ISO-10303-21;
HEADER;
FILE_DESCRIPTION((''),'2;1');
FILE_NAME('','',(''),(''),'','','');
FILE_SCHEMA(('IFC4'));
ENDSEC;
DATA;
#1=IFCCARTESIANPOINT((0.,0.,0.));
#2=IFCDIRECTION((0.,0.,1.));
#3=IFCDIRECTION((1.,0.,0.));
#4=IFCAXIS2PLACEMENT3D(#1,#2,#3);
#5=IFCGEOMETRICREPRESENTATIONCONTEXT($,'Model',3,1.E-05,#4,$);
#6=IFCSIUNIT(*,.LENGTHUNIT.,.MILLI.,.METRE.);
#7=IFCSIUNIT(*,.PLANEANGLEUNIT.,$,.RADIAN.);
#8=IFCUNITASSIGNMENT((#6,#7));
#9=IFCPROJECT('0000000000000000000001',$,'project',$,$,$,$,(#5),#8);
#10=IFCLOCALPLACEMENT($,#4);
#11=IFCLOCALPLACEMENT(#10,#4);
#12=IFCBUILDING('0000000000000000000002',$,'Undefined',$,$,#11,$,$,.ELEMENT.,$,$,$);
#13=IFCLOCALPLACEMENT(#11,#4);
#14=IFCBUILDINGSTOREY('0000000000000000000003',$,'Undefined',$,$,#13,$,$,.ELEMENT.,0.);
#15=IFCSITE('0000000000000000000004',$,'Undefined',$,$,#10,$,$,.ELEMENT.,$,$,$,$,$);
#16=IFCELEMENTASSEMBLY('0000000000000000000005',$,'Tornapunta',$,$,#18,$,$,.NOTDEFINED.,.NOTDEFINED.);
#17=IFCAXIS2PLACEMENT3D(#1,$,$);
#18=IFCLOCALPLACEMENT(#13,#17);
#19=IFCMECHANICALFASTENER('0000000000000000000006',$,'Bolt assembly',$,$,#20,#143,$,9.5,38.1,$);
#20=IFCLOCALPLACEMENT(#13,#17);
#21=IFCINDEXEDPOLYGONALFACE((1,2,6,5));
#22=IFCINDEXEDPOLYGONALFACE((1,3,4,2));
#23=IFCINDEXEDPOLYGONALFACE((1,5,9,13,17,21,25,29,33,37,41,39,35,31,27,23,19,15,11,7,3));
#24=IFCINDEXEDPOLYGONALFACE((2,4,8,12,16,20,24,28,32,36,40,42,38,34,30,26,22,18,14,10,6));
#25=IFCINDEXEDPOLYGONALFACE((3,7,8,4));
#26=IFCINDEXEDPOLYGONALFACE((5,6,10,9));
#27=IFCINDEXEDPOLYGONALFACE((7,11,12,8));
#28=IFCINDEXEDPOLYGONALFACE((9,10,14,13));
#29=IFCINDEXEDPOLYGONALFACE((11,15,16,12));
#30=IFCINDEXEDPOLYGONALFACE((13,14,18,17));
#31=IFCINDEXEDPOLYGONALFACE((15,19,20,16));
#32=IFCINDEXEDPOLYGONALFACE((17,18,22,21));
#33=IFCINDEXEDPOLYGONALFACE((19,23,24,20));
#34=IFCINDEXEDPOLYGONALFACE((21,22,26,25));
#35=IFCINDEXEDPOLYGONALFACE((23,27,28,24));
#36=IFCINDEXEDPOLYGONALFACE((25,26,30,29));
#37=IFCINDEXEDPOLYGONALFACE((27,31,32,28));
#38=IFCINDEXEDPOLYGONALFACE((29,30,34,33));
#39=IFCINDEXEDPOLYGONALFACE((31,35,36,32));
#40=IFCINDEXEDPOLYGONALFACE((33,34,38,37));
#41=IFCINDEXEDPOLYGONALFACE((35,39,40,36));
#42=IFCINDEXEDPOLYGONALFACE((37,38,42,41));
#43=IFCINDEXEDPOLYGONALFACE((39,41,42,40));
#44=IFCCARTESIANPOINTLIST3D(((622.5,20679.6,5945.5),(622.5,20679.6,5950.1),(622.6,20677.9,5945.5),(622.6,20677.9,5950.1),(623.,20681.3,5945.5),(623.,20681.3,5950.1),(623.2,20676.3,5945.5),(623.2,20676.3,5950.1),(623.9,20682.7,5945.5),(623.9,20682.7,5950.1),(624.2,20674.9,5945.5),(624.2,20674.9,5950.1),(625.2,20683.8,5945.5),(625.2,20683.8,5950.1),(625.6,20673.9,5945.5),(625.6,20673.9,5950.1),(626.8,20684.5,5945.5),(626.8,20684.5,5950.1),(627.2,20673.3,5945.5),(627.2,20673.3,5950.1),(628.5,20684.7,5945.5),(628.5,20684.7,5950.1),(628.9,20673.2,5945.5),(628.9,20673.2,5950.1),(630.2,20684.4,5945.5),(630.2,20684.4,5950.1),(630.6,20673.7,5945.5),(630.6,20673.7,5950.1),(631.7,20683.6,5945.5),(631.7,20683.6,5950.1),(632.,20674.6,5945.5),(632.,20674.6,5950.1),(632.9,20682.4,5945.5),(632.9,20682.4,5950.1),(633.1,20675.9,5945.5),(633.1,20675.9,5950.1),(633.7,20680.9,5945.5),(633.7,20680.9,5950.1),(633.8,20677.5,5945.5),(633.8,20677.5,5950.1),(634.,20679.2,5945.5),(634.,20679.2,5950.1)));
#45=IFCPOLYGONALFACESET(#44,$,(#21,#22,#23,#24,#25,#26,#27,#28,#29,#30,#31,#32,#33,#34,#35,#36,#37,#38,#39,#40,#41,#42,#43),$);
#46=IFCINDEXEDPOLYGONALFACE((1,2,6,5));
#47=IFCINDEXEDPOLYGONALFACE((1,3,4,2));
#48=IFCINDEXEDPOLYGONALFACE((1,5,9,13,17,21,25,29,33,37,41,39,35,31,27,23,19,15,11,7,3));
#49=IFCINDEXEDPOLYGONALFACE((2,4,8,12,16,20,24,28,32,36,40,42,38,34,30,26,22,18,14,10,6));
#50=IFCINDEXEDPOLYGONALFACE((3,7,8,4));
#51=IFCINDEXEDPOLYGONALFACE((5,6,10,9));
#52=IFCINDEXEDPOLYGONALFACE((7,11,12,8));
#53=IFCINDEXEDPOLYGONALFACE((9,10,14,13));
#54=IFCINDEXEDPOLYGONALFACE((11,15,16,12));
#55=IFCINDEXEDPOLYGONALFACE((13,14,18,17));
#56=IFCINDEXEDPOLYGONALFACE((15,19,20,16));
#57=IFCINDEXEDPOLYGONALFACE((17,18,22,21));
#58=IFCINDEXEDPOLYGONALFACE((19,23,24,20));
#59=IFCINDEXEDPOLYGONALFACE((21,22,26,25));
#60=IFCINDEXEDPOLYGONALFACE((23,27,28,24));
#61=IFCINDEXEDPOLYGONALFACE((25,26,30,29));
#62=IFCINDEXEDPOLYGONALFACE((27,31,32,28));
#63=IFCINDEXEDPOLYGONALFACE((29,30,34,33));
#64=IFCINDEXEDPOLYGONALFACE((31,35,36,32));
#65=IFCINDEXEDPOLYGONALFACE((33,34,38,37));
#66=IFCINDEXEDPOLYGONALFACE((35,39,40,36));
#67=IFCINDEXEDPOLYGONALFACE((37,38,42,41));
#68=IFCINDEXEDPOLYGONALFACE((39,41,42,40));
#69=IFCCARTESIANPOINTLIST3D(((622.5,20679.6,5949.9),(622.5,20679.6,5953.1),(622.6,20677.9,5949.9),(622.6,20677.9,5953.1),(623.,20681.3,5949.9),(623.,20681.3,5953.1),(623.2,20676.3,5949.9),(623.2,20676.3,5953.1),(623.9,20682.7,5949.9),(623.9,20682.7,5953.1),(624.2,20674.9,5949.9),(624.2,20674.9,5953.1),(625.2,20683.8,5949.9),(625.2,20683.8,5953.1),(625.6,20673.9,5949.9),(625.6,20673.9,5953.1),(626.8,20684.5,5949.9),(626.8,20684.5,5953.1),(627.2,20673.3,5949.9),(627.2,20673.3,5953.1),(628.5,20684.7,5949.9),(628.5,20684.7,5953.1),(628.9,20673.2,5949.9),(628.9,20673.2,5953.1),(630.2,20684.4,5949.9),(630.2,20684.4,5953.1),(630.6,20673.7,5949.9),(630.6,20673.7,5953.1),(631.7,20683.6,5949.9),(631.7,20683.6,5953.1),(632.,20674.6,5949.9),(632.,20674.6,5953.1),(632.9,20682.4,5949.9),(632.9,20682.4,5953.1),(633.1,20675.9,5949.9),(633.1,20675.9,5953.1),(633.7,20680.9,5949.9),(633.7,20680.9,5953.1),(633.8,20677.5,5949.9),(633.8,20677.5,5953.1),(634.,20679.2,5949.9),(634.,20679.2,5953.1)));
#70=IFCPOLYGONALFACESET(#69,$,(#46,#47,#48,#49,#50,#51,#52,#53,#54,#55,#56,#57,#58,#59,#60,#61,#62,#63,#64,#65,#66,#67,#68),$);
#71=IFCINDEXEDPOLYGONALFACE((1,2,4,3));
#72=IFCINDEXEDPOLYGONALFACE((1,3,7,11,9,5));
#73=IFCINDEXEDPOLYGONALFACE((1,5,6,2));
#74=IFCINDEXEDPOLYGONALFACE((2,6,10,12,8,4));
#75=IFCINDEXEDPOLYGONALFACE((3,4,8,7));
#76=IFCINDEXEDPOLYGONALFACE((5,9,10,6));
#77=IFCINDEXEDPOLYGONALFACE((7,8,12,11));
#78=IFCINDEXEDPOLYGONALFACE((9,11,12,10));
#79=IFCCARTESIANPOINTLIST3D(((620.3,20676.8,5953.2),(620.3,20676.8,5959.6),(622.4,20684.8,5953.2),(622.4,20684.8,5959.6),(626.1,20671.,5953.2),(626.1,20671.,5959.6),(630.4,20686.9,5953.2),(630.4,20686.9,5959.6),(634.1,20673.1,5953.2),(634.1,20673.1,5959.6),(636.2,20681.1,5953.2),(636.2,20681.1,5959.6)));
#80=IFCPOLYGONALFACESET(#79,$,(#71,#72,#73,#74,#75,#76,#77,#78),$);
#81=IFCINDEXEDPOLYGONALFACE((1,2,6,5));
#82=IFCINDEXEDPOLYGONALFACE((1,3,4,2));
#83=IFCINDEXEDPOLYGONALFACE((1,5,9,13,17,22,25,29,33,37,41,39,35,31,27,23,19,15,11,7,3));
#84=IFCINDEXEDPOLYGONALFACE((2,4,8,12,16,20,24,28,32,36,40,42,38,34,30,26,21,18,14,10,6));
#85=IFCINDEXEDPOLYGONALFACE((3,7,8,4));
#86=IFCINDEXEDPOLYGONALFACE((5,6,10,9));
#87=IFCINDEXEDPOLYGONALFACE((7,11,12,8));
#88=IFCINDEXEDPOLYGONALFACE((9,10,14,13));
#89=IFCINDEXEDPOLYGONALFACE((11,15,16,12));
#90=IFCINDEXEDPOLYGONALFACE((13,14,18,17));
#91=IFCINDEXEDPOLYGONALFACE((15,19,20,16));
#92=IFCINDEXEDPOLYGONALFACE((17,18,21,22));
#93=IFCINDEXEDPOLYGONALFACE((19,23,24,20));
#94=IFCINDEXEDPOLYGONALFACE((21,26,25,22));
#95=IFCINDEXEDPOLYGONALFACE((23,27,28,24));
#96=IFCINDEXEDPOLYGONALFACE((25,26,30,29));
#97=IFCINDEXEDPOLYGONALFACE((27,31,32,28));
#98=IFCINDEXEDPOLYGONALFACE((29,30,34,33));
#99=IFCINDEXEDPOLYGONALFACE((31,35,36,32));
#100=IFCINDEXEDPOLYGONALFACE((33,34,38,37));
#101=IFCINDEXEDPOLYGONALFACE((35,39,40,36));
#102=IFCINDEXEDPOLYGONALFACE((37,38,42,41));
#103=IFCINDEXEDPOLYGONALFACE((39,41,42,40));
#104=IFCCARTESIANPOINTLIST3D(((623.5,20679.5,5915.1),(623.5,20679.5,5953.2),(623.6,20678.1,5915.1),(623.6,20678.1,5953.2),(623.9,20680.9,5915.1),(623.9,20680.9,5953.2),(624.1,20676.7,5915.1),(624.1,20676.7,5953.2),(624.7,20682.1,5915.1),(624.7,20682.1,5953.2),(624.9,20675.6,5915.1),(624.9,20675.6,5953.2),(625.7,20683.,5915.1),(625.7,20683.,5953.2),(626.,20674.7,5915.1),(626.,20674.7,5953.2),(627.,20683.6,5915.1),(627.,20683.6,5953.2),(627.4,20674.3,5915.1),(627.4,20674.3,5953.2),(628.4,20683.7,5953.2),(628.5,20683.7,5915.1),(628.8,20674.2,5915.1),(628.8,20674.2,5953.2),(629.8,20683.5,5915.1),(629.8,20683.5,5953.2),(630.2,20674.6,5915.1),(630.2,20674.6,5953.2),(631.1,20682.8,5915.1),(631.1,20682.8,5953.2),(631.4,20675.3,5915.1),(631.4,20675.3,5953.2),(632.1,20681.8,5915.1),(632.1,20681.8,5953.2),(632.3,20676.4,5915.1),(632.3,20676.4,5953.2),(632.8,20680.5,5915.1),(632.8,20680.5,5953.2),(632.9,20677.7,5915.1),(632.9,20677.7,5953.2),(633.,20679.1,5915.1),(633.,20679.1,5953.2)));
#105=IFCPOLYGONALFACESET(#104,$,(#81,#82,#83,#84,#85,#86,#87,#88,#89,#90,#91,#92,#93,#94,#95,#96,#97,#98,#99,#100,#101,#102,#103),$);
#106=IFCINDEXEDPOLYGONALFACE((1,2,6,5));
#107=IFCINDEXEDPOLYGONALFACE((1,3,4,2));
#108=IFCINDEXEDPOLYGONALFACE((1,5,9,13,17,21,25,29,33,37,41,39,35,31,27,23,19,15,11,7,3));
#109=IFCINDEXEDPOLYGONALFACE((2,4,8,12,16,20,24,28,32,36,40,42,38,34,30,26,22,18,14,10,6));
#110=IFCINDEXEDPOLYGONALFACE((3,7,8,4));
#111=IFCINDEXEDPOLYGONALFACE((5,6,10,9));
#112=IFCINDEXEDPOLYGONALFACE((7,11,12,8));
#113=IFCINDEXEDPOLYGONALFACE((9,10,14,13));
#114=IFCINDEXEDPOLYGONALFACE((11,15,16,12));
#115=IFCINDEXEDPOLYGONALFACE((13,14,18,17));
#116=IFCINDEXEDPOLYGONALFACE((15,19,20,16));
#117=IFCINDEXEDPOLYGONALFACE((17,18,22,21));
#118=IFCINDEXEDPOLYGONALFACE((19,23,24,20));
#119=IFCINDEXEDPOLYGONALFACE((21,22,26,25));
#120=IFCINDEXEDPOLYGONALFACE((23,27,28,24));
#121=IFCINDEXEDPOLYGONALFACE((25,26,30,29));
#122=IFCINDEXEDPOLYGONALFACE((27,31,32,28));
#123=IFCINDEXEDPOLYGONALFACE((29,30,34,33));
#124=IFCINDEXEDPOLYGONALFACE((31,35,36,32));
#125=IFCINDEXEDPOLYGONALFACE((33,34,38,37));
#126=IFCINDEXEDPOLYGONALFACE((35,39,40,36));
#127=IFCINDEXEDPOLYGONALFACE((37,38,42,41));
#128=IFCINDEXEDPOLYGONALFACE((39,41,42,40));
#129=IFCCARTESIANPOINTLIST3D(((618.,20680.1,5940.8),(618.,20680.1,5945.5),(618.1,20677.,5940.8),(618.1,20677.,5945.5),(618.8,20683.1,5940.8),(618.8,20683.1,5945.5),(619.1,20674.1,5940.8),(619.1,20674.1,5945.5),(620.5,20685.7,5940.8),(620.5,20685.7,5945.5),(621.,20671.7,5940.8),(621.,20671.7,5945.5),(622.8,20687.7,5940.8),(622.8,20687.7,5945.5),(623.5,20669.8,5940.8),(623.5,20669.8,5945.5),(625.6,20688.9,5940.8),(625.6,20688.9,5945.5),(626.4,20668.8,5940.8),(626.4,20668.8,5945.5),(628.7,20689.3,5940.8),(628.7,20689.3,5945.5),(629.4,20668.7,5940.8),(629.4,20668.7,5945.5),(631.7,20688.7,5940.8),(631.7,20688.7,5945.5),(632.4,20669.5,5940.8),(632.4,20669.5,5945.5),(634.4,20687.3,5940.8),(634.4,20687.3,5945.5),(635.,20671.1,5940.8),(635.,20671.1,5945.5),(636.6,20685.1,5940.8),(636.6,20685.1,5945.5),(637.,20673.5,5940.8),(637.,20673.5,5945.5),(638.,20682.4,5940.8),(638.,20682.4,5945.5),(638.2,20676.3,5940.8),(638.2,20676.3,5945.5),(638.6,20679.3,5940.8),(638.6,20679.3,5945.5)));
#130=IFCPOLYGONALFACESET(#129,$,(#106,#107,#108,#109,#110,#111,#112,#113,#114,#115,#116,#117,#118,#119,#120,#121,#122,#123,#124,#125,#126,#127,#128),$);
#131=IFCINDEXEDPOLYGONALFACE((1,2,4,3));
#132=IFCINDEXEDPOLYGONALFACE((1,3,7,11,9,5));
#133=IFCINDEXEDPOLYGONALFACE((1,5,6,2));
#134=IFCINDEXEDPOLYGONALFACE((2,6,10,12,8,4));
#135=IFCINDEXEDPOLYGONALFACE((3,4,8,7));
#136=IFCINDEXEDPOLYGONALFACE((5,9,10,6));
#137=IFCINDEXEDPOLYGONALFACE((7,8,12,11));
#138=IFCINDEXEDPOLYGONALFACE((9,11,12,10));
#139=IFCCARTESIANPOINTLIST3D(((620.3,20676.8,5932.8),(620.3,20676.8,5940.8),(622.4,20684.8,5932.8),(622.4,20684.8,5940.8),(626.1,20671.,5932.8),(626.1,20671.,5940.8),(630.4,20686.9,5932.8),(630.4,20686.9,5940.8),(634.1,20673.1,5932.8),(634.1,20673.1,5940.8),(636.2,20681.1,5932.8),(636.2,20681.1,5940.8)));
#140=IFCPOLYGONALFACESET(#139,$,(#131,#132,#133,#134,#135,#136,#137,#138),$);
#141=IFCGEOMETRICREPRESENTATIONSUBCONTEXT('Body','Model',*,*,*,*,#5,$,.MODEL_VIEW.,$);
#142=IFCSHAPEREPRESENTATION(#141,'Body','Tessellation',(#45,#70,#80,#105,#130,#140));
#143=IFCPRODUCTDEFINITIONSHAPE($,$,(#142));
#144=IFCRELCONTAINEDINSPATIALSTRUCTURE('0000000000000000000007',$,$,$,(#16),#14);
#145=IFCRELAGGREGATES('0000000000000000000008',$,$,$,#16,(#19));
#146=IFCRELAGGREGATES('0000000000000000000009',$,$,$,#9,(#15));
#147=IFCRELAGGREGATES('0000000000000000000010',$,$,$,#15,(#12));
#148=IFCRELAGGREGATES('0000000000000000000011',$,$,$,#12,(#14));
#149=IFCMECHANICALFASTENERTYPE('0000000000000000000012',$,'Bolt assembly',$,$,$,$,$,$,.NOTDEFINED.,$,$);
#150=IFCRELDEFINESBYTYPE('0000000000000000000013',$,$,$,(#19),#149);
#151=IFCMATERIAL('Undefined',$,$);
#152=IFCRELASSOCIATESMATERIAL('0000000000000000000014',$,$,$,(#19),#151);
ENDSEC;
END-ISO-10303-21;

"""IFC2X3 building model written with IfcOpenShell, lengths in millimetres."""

from ifc_helpers import new_model, si_unit, frame, origin_with_axes, origin_2d_with_axis, place, context, subcontext, project, spatial, polyline, circle, outline, extrude, source, transform, mapped, material, type_object, element, aggregate, save


model = new_model("IFC2X3")

# Units and contexts
model_context = context("Model", 3, precision=1e-05, world=origin_with_axes())
body_context = subcontext(model_context, "Body", "Model", "MODEL_VIEW")
ifc_project = project(units=[si_unit("LENGTHUNIT", "METRE", prefix="MILLI"), si_unit("PLANEANGLEUNIT", "RADIAN")], contexts=[model_context])

# Site, building, storey
site_placement = place(None, origin_with_axes())
site = spatial("IfcSite", under=ifc_project, at=site_placement, Name="Undefined", CompositionType="ELEMENT")
building_placement = place(site_placement, origin_with_axes())
building = spatial("IfcBuilding", under=site, at=building_placement, Name="Undefined", CompositionType="ELEMENT")
storey_placement = place(building_placement, origin_with_axes())
storey = spatial("IfcBuildingStorey", under=building, at=storey_placement, Name="Undefined", CompositionType="ELEMENT", Elevation=0.0)

# Element assembly
assembly_1_placement = place(storey_placement, origin_with_axes())
assembly_1 = element("IfcElementAssembly", 1, at=assembly_1_placement, inside=storey, Name="Tornapunta", AssemblyPlace="NOTDEFINED", PredefinedType="NOTDEFINED")

# Mechanical fastener
ifc_material_1 = material(Name="Undefined")
mechanical_fastener_type = type_object("IfcMechanicalFastenerType", Name="Bolt assembly")
shared_shape_1 = source(origin_with_axes(), body_context, "Body", "SweptSolid", [
    extrude(circle(Radius=5.8, at=origin_2d_with_axis()), frame((0.0, -0.1, 0.0), z_axis=(0.0, 1.0, 0.0), x_axis=(1.0, 0.0, 0.0)), (0.0, 0.0, 1.0), 4.6),
    extrude(circle(Radius=5.8, at=origin_2d_with_axis()), frame((0.0, -3.1, 0.0), z_axis=(0.0, 1.0, 0.0), x_axis=(1.0, 0.0, 0.0)), (0.0, 0.0, 1.0), 3.2),
    extrude(outline(polyline([(7.1, -4.1), (7.1, 4.1), (0.0, 8.2), (-7.1, 4.1), (-7.1, -4.1), (0.0, -8.2), (7.1, -4.1)])), frame((0.0, -9.5, 0.0), z_axis=(0.0, 1.0, 0.0), x_axis=(1.0, 0.0, 0.0)), (0.0, 0.0, 1.0), 6.3),
    extrude(circle(Radius=4.8, at=origin_2d_with_axis()), frame((0.0, -3.2, 0.0), z_axis=(0.0, 1.0, 0.0), x_axis=(1.0, 0.0, 0.0)), (0.0, 0.0, 1.0), 38.1),
    extrude(circle(Radius=10.3, at=origin_2d_with_axis()), frame((0.0, 4.5, 0.0), z_axis=(0.0, 1.0, 0.0), x_axis=(1.0, 0.0, 0.0)), (0.0, 0.0, 1.0), 4.8),
    extrude(outline(polyline([(7.1, -4.1), (7.1, 4.1), (0.0, 8.2), (-7.1, 4.1), (-7.1, -4.1), (0.0, -8.2), (7.1, -4.1)])), frame((0.0, 9.3, 0.0), z_axis=(0.0, 1.0, 0.0), x_axis=(1.0, 0.0, 0.0)), (0.0, 0.0, 1.0), 7.9),
])
mechanical_fastener_1_placement = place(assembly_1_placement, frame((628.3, 20679.0, 5950.0), z_axis=(0.707107, -0.707107, 0.000016), x_axis=(-0.707107, -0.707107, -0.000016)))
mechanical_fastener_1 = element("IfcMechanicalFastener", 2, at=mechanical_fastener_1_placement, type_object=mechanical_fastener_type, material=ifc_material_1, Name="Bolt assembly", NominalDiameter=9.5, NominalLength=38.1, context=body_context, shape_type="MappedRepresentation", body=[
    mapped(shared_shape_1, transform((0.0, 0.0, 0.0))),
])
aggregate(assembly_1, [mechanical_fastener_1])

save(model, "model.ifc")
